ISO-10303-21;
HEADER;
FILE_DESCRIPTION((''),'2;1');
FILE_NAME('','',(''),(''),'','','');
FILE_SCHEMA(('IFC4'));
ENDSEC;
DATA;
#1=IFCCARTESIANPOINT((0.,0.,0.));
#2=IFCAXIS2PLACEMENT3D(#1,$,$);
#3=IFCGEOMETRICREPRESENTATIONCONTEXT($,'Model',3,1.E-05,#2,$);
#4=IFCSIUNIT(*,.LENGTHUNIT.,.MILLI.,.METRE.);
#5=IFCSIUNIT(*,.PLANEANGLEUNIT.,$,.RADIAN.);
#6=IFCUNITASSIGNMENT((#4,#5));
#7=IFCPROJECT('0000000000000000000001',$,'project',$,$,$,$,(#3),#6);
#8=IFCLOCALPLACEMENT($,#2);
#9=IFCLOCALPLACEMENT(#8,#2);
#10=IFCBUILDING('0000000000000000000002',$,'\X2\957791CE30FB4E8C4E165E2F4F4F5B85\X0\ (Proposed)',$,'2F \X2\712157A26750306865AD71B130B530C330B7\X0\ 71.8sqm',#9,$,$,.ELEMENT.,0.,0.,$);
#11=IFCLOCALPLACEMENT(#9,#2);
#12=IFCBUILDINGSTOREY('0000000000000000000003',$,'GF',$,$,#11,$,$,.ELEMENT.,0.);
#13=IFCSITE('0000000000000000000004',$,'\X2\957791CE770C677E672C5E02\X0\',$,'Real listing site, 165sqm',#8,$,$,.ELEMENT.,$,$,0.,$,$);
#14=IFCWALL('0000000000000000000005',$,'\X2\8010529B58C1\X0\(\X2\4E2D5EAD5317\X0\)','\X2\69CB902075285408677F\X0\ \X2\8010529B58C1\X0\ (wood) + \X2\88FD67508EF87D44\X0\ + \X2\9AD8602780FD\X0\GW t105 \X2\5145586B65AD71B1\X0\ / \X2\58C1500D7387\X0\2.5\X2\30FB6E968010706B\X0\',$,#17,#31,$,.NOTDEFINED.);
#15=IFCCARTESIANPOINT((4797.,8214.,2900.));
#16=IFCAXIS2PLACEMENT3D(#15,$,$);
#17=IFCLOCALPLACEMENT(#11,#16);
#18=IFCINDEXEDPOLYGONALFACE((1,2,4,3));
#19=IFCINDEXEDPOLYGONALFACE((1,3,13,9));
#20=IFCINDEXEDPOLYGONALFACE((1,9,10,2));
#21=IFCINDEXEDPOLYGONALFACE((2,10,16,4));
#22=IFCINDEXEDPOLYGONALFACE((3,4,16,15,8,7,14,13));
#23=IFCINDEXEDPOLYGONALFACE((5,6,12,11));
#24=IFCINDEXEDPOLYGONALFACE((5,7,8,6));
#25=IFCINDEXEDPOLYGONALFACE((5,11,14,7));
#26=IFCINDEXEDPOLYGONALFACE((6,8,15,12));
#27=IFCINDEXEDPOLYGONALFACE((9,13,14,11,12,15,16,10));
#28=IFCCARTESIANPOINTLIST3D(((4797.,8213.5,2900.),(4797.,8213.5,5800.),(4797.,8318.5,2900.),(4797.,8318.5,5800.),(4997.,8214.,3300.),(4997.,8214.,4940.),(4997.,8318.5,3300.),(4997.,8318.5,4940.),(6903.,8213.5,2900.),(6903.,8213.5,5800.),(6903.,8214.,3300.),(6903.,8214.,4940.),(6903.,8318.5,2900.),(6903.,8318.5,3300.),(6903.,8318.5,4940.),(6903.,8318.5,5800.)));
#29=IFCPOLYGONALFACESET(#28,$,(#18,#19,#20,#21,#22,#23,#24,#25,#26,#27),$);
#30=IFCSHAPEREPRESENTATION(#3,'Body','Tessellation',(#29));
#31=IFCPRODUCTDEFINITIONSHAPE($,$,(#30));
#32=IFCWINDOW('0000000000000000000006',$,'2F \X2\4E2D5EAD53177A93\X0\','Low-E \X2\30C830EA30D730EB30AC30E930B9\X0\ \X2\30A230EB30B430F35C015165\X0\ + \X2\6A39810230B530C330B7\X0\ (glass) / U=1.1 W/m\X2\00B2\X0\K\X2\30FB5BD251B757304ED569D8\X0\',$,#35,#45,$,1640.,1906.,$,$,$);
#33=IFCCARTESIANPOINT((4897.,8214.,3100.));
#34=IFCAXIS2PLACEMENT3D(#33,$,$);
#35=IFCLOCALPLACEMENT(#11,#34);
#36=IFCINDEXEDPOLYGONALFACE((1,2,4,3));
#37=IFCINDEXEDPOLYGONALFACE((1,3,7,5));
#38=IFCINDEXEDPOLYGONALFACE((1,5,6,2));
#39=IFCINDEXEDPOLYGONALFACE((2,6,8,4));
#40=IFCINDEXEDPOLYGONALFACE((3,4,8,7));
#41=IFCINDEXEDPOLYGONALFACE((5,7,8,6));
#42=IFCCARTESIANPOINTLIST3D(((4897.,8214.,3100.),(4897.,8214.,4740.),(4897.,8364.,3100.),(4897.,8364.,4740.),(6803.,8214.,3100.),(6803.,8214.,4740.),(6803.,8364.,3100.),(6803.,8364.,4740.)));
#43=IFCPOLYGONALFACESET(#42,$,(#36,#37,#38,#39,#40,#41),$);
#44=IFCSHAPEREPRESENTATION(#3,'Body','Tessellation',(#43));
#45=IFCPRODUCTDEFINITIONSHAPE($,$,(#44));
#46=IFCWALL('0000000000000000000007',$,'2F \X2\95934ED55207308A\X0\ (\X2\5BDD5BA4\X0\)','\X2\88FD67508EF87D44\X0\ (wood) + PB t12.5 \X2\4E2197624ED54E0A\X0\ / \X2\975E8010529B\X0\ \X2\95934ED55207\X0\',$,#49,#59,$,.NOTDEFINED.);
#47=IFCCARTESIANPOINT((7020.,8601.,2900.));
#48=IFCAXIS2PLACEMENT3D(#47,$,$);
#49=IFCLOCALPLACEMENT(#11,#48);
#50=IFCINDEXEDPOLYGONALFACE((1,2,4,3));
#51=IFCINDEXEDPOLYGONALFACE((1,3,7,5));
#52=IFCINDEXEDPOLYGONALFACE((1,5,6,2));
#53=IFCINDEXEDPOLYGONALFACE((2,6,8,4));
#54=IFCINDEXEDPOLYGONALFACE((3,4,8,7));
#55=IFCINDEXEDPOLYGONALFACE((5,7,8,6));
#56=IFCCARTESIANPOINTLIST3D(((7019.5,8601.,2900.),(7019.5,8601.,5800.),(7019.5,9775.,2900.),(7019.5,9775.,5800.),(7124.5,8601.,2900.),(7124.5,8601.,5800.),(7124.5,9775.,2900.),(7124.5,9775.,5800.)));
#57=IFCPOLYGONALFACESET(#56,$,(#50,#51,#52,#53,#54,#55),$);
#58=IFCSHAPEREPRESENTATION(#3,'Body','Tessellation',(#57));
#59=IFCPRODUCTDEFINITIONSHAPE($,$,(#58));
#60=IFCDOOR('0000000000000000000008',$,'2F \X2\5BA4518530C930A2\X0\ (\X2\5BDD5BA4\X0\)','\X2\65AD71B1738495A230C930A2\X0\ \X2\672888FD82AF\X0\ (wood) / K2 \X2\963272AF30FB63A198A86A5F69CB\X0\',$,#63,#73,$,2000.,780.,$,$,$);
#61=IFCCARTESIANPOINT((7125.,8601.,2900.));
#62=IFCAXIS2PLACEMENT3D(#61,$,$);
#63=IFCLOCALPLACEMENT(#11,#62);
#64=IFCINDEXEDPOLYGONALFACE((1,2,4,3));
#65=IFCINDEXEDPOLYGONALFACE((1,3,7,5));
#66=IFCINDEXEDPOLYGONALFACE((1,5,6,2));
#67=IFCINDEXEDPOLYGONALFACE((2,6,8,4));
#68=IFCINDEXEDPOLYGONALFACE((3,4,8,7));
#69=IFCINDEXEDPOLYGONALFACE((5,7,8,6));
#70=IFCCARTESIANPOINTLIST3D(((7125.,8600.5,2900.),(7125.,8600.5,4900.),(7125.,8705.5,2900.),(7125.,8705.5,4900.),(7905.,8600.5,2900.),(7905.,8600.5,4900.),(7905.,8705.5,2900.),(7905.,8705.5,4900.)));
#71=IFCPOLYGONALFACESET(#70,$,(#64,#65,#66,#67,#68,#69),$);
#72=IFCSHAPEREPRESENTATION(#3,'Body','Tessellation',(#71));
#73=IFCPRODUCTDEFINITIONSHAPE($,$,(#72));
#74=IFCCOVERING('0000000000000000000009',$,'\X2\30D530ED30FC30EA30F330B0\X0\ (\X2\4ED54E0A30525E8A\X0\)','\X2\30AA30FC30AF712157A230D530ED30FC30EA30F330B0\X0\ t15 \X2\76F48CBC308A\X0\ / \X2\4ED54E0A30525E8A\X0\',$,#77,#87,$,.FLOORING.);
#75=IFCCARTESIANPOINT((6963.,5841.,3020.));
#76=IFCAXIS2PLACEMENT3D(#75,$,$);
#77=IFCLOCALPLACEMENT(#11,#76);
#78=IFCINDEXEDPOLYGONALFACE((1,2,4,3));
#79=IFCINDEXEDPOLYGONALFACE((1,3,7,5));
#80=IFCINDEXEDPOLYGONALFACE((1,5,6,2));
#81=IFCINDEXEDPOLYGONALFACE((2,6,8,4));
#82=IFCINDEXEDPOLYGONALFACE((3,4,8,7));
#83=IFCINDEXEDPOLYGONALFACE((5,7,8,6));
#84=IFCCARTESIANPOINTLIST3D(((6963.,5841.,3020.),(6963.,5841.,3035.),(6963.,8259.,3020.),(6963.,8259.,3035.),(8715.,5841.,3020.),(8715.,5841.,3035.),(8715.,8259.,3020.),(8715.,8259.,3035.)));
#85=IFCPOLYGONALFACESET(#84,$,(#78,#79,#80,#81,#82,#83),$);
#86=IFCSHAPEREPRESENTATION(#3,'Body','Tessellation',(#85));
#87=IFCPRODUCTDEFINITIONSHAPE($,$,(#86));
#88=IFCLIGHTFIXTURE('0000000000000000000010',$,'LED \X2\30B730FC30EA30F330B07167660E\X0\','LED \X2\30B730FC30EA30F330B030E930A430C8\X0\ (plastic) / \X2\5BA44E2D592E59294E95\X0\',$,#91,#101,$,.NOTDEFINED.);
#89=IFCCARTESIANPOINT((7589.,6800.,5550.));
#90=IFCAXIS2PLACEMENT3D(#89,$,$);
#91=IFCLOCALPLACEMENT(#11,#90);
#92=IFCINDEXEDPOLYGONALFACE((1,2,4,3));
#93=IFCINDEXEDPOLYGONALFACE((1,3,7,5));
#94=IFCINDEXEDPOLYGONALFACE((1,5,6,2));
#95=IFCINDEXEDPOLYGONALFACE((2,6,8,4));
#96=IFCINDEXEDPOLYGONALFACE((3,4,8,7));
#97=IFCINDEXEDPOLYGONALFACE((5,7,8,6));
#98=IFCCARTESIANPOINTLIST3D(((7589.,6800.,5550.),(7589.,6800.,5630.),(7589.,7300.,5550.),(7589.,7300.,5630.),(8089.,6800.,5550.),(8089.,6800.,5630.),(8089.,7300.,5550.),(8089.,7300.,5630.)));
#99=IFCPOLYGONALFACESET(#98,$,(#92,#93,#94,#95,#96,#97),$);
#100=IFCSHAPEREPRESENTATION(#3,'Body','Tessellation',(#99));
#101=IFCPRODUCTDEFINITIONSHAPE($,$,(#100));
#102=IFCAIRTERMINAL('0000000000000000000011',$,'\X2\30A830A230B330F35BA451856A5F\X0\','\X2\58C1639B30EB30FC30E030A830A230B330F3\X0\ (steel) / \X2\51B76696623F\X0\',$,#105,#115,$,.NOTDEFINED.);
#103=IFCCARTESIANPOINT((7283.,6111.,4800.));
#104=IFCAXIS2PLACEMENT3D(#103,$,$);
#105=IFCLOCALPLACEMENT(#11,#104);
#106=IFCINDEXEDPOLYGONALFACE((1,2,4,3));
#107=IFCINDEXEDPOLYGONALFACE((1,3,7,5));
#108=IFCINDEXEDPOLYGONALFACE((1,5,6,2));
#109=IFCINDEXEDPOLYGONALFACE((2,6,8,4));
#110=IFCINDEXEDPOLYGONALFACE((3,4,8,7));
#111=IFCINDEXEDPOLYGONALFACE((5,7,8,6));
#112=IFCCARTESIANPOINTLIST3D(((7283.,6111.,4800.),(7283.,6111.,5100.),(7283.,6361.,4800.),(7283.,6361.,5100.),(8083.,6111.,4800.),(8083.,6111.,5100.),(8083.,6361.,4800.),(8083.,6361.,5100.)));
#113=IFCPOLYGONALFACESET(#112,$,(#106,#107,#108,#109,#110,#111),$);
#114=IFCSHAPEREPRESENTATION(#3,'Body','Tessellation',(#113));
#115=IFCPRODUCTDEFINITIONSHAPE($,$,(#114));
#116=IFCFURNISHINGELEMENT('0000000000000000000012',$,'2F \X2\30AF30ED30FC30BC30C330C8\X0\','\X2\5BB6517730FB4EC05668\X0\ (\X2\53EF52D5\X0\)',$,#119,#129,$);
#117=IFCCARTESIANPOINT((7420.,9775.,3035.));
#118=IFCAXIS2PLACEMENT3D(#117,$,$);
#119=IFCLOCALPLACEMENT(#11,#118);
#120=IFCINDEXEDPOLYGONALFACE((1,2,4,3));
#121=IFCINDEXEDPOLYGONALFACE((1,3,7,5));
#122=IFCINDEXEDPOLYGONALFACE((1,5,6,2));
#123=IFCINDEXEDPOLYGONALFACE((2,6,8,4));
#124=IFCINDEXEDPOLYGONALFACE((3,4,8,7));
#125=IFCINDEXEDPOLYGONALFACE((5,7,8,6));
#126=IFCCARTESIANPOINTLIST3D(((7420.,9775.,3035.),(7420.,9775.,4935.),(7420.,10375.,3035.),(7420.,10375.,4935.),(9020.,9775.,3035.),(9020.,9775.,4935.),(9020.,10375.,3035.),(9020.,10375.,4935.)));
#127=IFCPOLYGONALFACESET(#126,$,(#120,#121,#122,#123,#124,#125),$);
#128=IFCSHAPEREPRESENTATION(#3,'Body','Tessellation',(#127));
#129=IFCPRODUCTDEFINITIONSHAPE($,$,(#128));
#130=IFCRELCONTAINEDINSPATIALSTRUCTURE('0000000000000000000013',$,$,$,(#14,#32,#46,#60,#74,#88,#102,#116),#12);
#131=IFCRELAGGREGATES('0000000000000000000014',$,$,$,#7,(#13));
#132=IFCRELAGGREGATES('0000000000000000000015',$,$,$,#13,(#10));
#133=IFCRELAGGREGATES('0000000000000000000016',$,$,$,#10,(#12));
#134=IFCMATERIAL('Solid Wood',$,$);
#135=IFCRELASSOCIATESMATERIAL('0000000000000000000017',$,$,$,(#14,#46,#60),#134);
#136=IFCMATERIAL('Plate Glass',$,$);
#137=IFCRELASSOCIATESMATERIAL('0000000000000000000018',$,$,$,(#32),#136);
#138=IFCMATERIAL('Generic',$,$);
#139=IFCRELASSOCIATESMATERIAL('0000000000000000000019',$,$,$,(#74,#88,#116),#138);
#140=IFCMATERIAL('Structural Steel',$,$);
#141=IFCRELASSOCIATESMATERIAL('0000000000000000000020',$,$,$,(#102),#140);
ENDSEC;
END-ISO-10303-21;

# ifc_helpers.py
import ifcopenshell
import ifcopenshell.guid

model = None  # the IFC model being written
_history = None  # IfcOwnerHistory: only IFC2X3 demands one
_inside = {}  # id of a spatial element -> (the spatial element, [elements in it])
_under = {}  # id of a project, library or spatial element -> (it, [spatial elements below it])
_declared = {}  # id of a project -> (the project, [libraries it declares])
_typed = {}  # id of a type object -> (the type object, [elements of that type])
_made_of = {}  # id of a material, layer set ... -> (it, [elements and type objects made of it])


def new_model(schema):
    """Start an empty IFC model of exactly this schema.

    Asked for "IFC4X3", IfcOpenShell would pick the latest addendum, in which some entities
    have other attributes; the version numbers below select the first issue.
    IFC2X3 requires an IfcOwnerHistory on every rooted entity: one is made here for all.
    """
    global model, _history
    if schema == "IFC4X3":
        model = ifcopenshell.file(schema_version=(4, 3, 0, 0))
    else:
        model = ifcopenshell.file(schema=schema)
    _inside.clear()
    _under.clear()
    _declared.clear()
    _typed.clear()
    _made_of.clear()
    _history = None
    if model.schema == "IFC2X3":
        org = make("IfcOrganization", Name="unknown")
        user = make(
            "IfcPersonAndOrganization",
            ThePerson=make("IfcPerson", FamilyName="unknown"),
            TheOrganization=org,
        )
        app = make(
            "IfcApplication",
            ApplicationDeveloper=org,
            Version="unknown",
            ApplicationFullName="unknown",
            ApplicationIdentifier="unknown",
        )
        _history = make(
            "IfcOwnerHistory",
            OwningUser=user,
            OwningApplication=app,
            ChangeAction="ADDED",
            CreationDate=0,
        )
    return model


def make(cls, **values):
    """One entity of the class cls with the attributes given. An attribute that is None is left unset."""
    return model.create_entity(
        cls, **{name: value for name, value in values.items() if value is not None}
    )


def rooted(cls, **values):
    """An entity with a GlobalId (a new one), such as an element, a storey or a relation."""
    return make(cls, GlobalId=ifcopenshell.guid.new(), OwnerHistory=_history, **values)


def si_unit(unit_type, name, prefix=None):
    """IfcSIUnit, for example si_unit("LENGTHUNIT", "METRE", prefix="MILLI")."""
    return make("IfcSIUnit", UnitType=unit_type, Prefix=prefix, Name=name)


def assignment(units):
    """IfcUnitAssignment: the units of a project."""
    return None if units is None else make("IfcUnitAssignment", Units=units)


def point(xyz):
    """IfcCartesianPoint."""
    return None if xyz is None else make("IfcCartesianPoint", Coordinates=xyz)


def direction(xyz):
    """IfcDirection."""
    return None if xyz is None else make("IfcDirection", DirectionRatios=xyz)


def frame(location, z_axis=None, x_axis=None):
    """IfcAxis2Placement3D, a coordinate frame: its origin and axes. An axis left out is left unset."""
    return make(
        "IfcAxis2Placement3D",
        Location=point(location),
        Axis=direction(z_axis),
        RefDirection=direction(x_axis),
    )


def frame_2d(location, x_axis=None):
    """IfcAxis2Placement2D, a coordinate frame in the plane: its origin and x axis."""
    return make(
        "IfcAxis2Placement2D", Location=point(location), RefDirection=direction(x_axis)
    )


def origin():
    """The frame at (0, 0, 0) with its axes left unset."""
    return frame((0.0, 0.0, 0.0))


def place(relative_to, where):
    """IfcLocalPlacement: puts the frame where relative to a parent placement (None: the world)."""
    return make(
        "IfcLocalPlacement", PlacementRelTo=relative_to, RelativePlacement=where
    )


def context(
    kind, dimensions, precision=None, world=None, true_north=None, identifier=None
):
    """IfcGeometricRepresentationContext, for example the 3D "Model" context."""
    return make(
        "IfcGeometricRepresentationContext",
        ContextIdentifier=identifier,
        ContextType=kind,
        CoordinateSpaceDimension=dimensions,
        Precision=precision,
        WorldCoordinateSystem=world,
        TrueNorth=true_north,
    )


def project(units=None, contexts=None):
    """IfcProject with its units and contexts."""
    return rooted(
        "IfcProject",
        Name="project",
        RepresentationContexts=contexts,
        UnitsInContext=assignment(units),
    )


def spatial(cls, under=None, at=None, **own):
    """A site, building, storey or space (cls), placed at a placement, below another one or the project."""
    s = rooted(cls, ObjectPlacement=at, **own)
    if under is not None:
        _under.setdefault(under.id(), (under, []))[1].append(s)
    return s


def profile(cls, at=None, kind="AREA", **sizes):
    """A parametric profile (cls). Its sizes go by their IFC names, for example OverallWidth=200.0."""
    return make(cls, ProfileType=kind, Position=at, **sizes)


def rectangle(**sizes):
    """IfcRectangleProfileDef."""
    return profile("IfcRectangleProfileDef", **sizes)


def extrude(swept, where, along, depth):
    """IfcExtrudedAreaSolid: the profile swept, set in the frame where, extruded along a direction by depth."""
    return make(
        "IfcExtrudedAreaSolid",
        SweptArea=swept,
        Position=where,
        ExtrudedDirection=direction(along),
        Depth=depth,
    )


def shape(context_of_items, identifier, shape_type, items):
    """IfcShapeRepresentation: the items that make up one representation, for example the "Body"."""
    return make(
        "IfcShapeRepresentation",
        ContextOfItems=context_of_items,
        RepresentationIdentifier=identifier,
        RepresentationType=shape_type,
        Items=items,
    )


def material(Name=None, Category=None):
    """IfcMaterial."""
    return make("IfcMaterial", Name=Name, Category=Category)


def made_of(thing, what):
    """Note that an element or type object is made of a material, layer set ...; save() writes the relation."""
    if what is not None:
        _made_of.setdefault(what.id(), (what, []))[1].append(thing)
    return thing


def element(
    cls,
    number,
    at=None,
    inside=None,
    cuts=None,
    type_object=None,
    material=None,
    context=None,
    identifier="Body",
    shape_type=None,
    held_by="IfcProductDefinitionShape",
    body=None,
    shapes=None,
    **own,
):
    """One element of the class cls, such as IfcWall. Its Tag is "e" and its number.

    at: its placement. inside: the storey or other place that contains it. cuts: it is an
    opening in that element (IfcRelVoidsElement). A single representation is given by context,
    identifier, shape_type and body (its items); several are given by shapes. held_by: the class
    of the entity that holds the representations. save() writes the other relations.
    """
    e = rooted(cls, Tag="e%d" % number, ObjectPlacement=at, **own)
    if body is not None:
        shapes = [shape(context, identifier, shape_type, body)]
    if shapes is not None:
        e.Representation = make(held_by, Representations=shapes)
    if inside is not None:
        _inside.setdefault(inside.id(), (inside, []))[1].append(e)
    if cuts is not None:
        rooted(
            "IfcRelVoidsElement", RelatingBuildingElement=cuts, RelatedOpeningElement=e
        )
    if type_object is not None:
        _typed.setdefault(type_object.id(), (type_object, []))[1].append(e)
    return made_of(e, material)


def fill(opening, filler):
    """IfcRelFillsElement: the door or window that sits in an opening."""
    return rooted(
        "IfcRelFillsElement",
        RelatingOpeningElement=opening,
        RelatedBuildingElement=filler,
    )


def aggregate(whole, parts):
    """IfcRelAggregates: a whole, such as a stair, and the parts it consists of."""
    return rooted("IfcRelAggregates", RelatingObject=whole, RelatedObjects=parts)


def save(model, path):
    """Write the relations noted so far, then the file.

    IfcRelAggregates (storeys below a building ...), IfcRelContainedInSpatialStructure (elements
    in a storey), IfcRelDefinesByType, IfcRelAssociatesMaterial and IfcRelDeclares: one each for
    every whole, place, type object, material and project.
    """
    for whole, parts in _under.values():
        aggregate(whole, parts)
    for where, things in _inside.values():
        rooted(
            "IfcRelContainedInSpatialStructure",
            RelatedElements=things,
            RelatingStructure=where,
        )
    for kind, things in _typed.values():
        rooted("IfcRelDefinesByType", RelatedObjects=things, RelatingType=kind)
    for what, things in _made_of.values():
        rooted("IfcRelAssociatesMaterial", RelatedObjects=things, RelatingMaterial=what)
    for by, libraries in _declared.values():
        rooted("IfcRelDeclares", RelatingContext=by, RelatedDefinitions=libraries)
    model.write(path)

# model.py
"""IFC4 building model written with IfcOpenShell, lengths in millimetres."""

from ifc_helpers import new_model, si_unit, frame, frame_2d, origin, place, context, project, spatial, rectangle, extrude, material, element, fill, save


model = new_model("IFC4")

# Units and contexts
model_context = context("Model", 3, precision=1e-05, world=origin())
ifc_project = project(units=[si_unit("LENGTHUNIT", "METRE", prefix="MILLI"), si_unit("PLANEANGLEUNIT", "RADIAN")], contexts=[model_context])

# Site, building, storey
site_placement = place(None, origin())
site = spatial("IfcSite", under=ifc_project, at=site_placement, Name="長野県松本市", ObjectType="Real listing site, 165sqm", CompositionType="ELEMENT", RefElevation=0.0)
building_placement = place(site_placement, origin())
building = spatial("IfcBuilding", under=site, at=building_placement, Name="長野・二世帯住宅 (Proposed)", ObjectType="2F 無垢材と断熱サッシ 71.8sqm", CompositionType="ELEMENT", ElevationOfRefHeight=0.0, ElevationOfTerrain=0.0)
storey_placement = place(building_placement, origin())
storey = spatial("IfcBuildingStorey", under=building, at=storey_placement, Name="GF", CompositionType="ELEMENT", Elevation=0.0)

# Shared definitions
ifc_material_1 = material(Name="Solid Wood")

# Wall, opening, window
wall_1_placement = place(storey_placement, frame((4797.0, 8214.0, 2900.0)))
wall_1 = element("IfcWall", 1, at=wall_1_placement, inside=storey, material=ifc_material_1, Name="耐力壁(中庭北)", Description="構造用合板 耐力壁 (wood) + 製材軸組 + 高性能GW t105 充填断熱 / 壁倍率2.5・準耐火", PredefinedType="NOTDEFINED", context=model_context, shape_type="SweptSolid", body=[
    extrude(rectangle(XDim=2106.0, YDim=105.0, at=frame_2d((1053.0, 52.0))), frame((4797.0, 8214.0, 2900.0)), (0.0, 0.0, 1.0), 2900.0),
])
opening_placement = place(storey_placement, frame((4897.0, 8214.0, 3100.0)))
opening = element("IfcOpeningElement", 2, at=opening_placement, cuts=wall_1, PredefinedType="NOTDEFINED", context=model_context, shape_type="SweptSolid", body=[
    extrude(rectangle(XDim=1906.0, YDim=150.0, at=frame_2d((953.0, 75.0))), frame((4897.0, 8214.0, 3100.0)), (0.0, 0.0, 1.0), 1640.0),
])
ifc_material_2 = material(Name="Plate Glass")
window_placement = place(storey_placement, frame((4897.0, 8214.0, 3100.0)))
window = element("IfcWindow", 3, at=window_placement, inside=storey, material=ifc_material_2, Name="2F 中庭北窓", Description="Low-E トリプルガラス アルゴン封入 + 樹脂サッシ (glass) / U=1.1 W/m²K・寒冷地仕様", OverallHeight=1640.0, OverallWidth=1906.0, context=model_context, shape_type="SweptSolid", body=[
    extrude(rectangle(XDim=1906.0, YDim=150.0, at=frame_2d((953.0, 75.0))), frame((4897.0, 8214.0, 3100.0)), (0.0, 0.0, 1.0), 1640.0),
])
fill(opening, window)

# Wall
wall_2_placement = place(storey_placement, frame((7020.0, 8601.0, 2900.0)))
element("IfcWall", 4, at=wall_2_placement, inside=storey, material=ifc_material_1, Name="2F 間仕切り (寝室)", Description="製材軸組 (wood) + PB t12.5 両面仕上 / 非耐力 間仕切", PredefinedType="NOTDEFINED", context=model_context, shape_type="SweptSolid", body=[
    extrude(rectangle(XDim=105.0, YDim=1174.0, at=frame_2d((52.0, 587.0))), frame((7020.0, 8601.0, 2900.0)), (0.0, 0.0, 1.0), 2900.0),
])

# Door
door_placement = place(storey_placement, frame((7125.0, 8601.0, 2900.0)))
element("IfcDoor", 5, at=door_placement, inside=storey, material=ifc_material_1, Name="2F 室内ドア (寝室)", Description="断熱玄関ドア 木製芯 (wood) / K2 防犯・採風機構", OverallHeight=2000.0, OverallWidth=780.0, context=model_context, shape_type="SweptSolid", body=[
    extrude(rectangle(XDim=780.0, YDim=105.0, at=frame_2d((390.0, 52.0))), frame((7125.0, 8601.0, 2900.0)), (0.0, 0.0, 1.0), 2000.0),
])

# Covering
ifc_material_3 = material(Name="Generic")
covering_placement = place(storey_placement, frame((6963.0, 5841.0, 3020.0)))
element("IfcCovering", 6, at=covering_placement, inside=storey, material=ifc_material_3, Name="フローリング (仕上げ床)", Description="オーク無垢フローリング t15 直貼り / 仕上げ床", PredefinedType="FLOORING", context=model_context, shape_type="SweptSolid", body=[
    extrude(rectangle(XDim=1752.0, YDim=2418.0, at=frame_2d((876.0, 1209.0))), frame((6963.0, 5841.0, 3020.0)), (0.0, 0.0, 1.0), 15.0),
])

# Light fixture
light_fixture_placement = place(storey_placement, frame((7589.0, 6800.0, 5550.0)))
element("IfcLightFixture", 7, at=light_fixture_placement, inside=storey, material=ifc_material_3, Name="LED シーリング照明", Description="LED シーリングライト (plastic) / 室中央天井", PredefinedType="NOTDEFINED", context=model_context, shape_type="SweptSolid", body=[
    extrude(rectangle(XDim=500.0, YDim=500.0, at=frame_2d((250.0, 250.0))), frame((7589.0, 6800.0, 5550.0)), (0.0, 0.0, 1.0), 80.0),
])

# Air terminal
ifc_material_4 = material(Name="Structural Steel")
air_terminal_placement = place(storey_placement, frame((7283.0, 6111.0, 4800.0)))
element("IfcAirTerminal", 8, at=air_terminal_placement, inside=storey, material=ifc_material_4, Name="エアコン室内機", Description="壁掛ルームエアコン (steel) / 冷暖房", PredefinedType="NOTDEFINED", context=model_context, shape_type="SweptSolid", body=[
    extrude(rectangle(XDim=800.0, YDim=250.0, at=frame_2d((400.0, 125.0))), frame((7283.0, 6111.0, 4800.0)), (0.0, 0.0, 1.0), 300.0),
])

# Furnishing element
furnishing_placement = place(storey_placement, frame((7420.0, 9775.0, 3035.0)))
element("IfcFurnishingElement", 9, at=furnishing_placement, inside=storey, material=ifc_material_3, Name="2F クローゼット", Description="家具・什器 (可動)", context=model_context, shape_type="SweptSolid", body=[
    extrude(rectangle(XDim=1600.0, YDim=600.0, at=frame_2d((800.0, 300.0))), frame((7420.0, 9775.0, 3035.0)), (0.0, 0.0, 1.0), 1900.0),
])

save(model, "model.ifc")
